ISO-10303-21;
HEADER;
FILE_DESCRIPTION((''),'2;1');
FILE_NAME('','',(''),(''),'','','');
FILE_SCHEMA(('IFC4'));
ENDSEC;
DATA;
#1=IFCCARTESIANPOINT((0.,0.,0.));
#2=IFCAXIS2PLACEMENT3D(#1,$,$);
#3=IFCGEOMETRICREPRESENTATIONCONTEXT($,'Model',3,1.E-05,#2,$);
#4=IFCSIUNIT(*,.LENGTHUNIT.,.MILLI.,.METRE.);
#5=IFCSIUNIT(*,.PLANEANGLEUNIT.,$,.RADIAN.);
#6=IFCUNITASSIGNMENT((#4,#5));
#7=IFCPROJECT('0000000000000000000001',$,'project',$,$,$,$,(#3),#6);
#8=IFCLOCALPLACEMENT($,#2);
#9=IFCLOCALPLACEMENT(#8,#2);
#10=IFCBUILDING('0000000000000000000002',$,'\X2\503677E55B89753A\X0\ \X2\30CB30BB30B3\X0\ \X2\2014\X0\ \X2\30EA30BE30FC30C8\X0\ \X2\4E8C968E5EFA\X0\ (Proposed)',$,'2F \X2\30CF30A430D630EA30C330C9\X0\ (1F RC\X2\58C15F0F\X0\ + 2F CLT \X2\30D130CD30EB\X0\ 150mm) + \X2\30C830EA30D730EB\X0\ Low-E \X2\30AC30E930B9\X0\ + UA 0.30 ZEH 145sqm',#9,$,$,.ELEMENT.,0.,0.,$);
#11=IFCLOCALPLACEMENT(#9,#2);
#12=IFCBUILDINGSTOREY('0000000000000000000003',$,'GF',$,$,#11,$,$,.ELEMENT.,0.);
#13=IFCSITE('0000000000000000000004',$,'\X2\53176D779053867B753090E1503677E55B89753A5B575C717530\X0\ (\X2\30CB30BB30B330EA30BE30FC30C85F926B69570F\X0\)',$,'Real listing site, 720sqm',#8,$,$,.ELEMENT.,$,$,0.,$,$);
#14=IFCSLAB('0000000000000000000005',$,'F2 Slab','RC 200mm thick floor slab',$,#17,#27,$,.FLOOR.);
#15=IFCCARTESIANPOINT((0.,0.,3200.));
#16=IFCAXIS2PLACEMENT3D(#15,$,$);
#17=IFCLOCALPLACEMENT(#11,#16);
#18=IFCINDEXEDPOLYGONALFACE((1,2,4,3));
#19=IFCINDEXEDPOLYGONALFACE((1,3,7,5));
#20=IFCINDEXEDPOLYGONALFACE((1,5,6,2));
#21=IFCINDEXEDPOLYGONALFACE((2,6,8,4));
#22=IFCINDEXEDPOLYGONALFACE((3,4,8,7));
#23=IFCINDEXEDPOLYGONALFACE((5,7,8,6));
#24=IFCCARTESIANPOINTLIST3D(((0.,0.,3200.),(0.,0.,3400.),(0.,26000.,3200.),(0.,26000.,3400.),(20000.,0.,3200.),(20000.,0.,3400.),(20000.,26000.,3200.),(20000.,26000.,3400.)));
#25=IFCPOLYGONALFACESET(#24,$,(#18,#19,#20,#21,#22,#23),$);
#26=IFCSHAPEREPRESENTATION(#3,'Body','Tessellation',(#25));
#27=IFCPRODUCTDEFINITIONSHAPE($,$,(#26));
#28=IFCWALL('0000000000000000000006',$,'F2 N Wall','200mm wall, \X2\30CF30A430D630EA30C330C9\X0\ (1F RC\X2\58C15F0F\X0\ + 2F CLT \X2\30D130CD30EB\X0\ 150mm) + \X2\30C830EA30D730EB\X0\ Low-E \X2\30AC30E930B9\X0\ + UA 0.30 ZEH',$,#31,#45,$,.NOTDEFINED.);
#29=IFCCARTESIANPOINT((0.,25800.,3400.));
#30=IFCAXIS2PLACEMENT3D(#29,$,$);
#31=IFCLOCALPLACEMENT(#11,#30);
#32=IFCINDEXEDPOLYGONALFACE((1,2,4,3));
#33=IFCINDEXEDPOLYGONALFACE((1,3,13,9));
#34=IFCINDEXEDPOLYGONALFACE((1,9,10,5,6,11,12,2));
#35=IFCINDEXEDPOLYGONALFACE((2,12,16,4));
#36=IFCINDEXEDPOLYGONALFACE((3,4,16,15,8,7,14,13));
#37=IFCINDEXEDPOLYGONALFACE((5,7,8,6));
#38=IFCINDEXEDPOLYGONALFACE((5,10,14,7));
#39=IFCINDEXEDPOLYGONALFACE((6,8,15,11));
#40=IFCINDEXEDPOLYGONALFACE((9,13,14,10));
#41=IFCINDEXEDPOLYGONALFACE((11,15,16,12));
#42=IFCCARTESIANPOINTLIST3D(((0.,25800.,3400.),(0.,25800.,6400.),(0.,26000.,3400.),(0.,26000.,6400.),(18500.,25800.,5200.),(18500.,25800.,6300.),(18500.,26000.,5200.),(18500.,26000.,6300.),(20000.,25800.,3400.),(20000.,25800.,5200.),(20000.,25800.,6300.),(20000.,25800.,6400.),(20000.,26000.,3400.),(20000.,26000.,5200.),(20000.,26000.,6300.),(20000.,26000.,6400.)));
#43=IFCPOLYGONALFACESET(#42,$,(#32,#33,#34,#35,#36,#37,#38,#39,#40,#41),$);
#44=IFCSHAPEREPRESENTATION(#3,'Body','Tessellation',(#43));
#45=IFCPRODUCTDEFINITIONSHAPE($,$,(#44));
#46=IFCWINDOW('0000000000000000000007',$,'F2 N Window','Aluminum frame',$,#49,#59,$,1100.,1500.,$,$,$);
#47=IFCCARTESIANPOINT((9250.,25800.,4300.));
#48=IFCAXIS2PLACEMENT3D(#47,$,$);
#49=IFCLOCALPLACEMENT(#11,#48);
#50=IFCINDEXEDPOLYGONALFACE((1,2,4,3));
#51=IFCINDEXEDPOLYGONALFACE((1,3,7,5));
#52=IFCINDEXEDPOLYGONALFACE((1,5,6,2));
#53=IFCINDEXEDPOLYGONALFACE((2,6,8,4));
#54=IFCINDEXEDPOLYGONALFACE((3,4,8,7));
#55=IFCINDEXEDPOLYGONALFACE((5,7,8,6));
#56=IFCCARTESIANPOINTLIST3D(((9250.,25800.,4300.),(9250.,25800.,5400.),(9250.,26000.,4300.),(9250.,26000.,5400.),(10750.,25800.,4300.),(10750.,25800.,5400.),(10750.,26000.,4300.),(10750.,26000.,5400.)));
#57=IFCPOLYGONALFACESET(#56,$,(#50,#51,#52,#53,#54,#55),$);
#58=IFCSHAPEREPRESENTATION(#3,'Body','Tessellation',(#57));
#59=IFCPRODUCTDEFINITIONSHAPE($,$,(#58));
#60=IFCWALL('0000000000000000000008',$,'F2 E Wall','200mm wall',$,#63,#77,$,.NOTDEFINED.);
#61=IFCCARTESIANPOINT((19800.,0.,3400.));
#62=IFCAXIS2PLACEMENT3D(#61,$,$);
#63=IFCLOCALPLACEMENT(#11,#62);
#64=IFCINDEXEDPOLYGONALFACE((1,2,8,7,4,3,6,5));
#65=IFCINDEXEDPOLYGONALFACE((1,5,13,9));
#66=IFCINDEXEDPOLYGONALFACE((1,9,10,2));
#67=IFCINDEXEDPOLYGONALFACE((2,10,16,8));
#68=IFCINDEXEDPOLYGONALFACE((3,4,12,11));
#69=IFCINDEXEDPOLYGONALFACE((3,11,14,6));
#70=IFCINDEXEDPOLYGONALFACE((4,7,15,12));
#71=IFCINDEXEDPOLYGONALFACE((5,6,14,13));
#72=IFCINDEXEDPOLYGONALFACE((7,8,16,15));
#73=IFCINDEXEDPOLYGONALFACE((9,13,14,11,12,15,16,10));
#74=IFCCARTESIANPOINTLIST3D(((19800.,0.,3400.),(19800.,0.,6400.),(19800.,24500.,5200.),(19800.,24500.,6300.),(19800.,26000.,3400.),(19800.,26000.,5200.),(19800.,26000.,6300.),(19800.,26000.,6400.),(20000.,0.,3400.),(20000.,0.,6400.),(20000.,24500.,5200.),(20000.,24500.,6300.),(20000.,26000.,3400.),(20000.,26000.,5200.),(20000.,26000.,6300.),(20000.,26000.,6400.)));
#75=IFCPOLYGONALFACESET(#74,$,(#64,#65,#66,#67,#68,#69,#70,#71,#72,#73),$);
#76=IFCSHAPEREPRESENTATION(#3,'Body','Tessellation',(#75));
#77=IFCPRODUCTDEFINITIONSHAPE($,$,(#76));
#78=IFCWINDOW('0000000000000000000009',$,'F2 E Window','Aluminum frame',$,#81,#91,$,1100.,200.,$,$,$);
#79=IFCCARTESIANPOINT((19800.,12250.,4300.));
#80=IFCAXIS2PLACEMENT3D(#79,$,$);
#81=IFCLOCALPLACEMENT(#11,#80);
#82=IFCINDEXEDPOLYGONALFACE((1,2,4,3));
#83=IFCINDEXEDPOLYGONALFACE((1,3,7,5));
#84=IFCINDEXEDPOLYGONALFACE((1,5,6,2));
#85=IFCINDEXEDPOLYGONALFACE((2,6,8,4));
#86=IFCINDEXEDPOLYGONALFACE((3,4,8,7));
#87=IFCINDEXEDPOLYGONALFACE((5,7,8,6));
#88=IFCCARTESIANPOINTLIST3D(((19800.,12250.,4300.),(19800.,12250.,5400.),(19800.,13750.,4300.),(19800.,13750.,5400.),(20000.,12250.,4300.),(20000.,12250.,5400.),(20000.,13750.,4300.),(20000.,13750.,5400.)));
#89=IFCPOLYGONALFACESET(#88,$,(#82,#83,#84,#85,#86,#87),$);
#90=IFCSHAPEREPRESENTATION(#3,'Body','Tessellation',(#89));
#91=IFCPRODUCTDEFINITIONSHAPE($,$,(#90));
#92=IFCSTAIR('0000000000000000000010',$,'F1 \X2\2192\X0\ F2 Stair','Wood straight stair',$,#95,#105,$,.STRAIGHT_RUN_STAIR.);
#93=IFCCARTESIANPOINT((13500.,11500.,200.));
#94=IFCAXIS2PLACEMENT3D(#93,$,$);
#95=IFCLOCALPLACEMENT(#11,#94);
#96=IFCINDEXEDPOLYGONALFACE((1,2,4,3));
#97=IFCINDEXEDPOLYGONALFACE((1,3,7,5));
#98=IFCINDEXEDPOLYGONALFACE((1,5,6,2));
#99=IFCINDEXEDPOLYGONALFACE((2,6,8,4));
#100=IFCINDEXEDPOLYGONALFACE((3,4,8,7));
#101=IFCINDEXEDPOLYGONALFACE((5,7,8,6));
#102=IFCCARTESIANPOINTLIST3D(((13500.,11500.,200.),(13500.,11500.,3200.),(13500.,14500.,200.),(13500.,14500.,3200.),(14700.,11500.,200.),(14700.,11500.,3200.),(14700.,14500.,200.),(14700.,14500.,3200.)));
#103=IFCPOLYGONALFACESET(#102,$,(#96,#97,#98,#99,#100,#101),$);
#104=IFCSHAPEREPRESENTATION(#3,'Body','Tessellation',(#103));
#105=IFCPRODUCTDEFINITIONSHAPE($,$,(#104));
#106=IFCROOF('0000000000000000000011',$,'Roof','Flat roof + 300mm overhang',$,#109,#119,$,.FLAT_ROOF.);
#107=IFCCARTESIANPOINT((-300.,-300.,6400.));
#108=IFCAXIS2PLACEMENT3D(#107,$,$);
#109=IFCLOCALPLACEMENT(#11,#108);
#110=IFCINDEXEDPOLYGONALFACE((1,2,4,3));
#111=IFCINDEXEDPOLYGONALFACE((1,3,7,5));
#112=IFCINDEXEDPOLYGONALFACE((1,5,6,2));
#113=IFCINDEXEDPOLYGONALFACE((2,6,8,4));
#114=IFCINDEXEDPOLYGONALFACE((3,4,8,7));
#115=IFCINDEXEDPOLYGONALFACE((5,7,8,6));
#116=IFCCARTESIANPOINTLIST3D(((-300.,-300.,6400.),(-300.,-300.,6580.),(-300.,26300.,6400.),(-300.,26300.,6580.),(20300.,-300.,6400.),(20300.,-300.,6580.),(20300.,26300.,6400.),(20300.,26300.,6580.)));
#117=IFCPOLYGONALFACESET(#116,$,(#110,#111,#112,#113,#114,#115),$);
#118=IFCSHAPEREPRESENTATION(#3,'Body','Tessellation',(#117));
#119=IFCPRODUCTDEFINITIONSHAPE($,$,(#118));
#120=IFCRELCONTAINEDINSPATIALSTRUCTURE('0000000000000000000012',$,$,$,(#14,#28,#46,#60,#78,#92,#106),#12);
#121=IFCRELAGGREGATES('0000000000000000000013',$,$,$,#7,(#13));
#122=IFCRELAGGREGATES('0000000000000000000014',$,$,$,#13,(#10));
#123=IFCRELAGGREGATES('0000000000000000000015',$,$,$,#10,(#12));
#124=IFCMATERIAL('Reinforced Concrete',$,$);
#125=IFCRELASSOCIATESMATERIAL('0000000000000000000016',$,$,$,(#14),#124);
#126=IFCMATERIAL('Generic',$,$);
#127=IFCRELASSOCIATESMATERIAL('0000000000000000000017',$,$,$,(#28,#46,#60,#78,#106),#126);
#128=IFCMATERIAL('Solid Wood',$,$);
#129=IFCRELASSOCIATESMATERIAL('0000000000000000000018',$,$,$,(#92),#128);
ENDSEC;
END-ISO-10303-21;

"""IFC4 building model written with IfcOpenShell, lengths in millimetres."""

from ifc_helpers import new_model, si_unit, frame, frame_2d, origin, place, context, project, spatial, rectangle, extrude, material, element, fill, save


model = new_model("IFC4")

# Units and contexts
model_context = context("Model", 3, precision=1e-05, world=origin())
ifc_project = project(units=[si_unit("LENGTHUNIT", "METRE", prefix="MILLI"), si_unit("PLANEANGLEUNIT", "RADIAN")], contexts=[model_context])

# Site, building, storey
site_placement = place(None, origin())
site = spatial("IfcSite", under=ifc_project, at=site_placement, Name="北海道虻田郡倶知安町字山田 (ニセコリゾート徒歩圏)", ObjectType="Real listing site, 720sqm", CompositionType="ELEMENT", RefElevation=0.0)
building_placement = place(site_placement, origin())
building = spatial("IfcBuilding", under=site, at=building_placement, Name="倶知安町 ニセコ — リゾート 二階建 (Proposed)", ObjectType="2F ハイブリッド (1F RC壁式 + 2F CLT パネル 150mm) + トリプル Low-E ガラス + UA 0.30 ZEH 145sqm", CompositionType="ELEMENT", ElevationOfRefHeight=0.0, ElevationOfTerrain=0.0)
storey_placement = place(building_placement, origin())
storey = spatial("IfcBuildingStorey", under=building, at=storey_placement, Name="GF", CompositionType="ELEMENT", Elevation=0.0)

# Slab
ifc_material_1 = material(Name="Reinforced Concrete")
slab_1_placement = place(storey_placement, frame((0.0, 0.0, 3200.0)))
element("IfcSlab", 1, at=slab_1_placement, inside=storey, material=ifc_material_1, Name="F2 Slab", Description="RC 200mm thick floor slab", PredefinedType="FLOOR", context=model_context, shape_type="SweptSolid", body=[
    extrude(rectangle(XDim=20000.0, YDim=26000.0, at=frame_2d((10000.0, 13000.0))), frame((0.0, 0.0, 3200.0)), (0.0, 0.0, 1.0), 200.0),
])

# Shared definitions
ifc_material_2 = material(Name="Generic")

# Shared definitions
ifc_material_3 = material(Name="Solid Wood")

# Walls, openings, windows
wall_1_placement = place(storey_placement, frame((0.0, 25800.0, 3400.0)))
wall_1 = element("IfcWall", 2, at=wall_1_placement, inside=storey, material=ifc_material_2, Name="F2 N Wall", Description="200mm wall, ハイブリッド (1F RC壁式 + 2F CLT パネル 150mm) + トリプル Low-E ガラス + UA 0.30 ZEH", PredefinedType="NOTDEFINED", context=model_context, shape_type="SweptSolid", body=[
    extrude(rectangle(XDim=20000.0, YDim=200.0, at=frame_2d((10000.0, 100.0))), frame((0.0, 25800.0, 3400.0)), (0.0, 0.0, 1.0), 3000.0),
])
opening_1_placement = place(storey_placement, frame((9250.0, 25800.0, 4300.0)))
opening_1 = element("IfcOpeningElement", 3, at=opening_1_placement, cuts=wall_1, PredefinedType="NOTDEFINED", context=model_context, shape_type="SweptSolid", body=[
    extrude(rectangle(XDim=1500.0, YDim=200.0, at=frame_2d((750.0, 100.0))), frame((9250.0, 25800.0, 4300.0)), (0.0, 0.0, 1.0), 1100.0),
])
window_1_placement = place(storey_placement, frame((9250.0, 25800.0, 4300.0)))
window_1 = element("IfcWindow", 4, at=window_1_placement, inside=storey, material=ifc_material_2, Name="F2 N Window", Description="Aluminum frame", OverallHeight=1100.0, OverallWidth=1500.0, context=model_context, shape_type="SweptSolid", body=[
    extrude(rectangle(XDim=1500.0, YDim=200.0, at=frame_2d((750.0, 100.0))), frame((9250.0, 25800.0, 4300.0)), (0.0, 0.0, 1.0), 1100.0),
])
fill(opening_1, window_1)
wall_2_placement = place(storey_placement, frame((19800.0, 0.0, 3400.0)))
wall_2 = element("IfcWall", 5, at=wall_2_placement, inside=storey, material=ifc_material_2, Name="F2 E Wall", Description="200mm wall", PredefinedType="NOTDEFINED", context=model_context, shape_type="SweptSolid", body=[
    extrude(rectangle(XDim=200.0, YDim=26000.0, at=frame_2d((100.0, 13000.0))), frame((19800.0, 0.0, 3400.0)), (0.0, 0.0, 1.0), 3000.0),
])
opening_2_placement = place(storey_placement, frame((19800.0, 12250.0, 4300.0)))
opening_2 = element("IfcOpeningElement", 6, at=opening_2_placement, cuts=wall_2, PredefinedType="NOTDEFINED", context=model_context, shape_type="SweptSolid", body=[
    extrude(rectangle(XDim=200.0, YDim=1500.0, at=frame_2d((100.0, 750.0))), frame((19800.0, 12250.0, 4300.0)), (0.0, 0.0, 1.0), 1100.0),
])
window_2_placement = place(storey_placement, frame((19800.0, 12250.0, 4300.0)))
window_2 = element("IfcWindow", 7, at=window_2_placement, inside=storey, material=ifc_material_2, Name="F2 E Window", Description="Aluminum frame", OverallHeight=1100.0, OverallWidth=200.0, context=model_context, shape_type="SweptSolid", body=[
    extrude(rectangle(XDim=200.0, YDim=1500.0, at=frame_2d((100.0, 750.0))), frame((19800.0, 12250.0, 4300.0)), (0.0, 0.0, 1.0), 1100.0),
])
fill(opening_2, window_2)

# Stair
stair_placement = place(storey_placement, frame((13500.0, 11500.0, 200.0)))
element("IfcStair", 8, at=stair_placement, inside=storey, material=ifc_material_3, Name="F1 → F2 Stair", Description="Wood straight stair", PredefinedType="STRAIGHT_RUN_STAIR", context=model_context, shape_type="SweptSolid", body=[
    extrude(rectangle(XDim=1200.0, YDim=3000.0, at=frame_2d((600.0, 1500.0))), frame((13500.0, 11500.0, 200.0)), (0.0, 0.0, 1.0), 3000.0),
])

# Roof
roof_placement = place(storey_placement, frame((-300.0, -300.0, 6400.0)))
element("IfcRoof", 9, at=roof_placement, inside=storey, material=ifc_material_2, Name="Roof", Description="Flat roof + 300mm overhang", PredefinedType="FLAT_ROOF", context=model_context, shape_type="SweptSolid", body=[
    extrude(rectangle(XDim=20600.0, YDim=26600.0, at=frame_2d((10300.0, 13300.0))), frame((-300.0, -300.0, 6400.0)), (0.0, 0.0, 1.0), 180.0),
])

save(model, "model.ifc")
